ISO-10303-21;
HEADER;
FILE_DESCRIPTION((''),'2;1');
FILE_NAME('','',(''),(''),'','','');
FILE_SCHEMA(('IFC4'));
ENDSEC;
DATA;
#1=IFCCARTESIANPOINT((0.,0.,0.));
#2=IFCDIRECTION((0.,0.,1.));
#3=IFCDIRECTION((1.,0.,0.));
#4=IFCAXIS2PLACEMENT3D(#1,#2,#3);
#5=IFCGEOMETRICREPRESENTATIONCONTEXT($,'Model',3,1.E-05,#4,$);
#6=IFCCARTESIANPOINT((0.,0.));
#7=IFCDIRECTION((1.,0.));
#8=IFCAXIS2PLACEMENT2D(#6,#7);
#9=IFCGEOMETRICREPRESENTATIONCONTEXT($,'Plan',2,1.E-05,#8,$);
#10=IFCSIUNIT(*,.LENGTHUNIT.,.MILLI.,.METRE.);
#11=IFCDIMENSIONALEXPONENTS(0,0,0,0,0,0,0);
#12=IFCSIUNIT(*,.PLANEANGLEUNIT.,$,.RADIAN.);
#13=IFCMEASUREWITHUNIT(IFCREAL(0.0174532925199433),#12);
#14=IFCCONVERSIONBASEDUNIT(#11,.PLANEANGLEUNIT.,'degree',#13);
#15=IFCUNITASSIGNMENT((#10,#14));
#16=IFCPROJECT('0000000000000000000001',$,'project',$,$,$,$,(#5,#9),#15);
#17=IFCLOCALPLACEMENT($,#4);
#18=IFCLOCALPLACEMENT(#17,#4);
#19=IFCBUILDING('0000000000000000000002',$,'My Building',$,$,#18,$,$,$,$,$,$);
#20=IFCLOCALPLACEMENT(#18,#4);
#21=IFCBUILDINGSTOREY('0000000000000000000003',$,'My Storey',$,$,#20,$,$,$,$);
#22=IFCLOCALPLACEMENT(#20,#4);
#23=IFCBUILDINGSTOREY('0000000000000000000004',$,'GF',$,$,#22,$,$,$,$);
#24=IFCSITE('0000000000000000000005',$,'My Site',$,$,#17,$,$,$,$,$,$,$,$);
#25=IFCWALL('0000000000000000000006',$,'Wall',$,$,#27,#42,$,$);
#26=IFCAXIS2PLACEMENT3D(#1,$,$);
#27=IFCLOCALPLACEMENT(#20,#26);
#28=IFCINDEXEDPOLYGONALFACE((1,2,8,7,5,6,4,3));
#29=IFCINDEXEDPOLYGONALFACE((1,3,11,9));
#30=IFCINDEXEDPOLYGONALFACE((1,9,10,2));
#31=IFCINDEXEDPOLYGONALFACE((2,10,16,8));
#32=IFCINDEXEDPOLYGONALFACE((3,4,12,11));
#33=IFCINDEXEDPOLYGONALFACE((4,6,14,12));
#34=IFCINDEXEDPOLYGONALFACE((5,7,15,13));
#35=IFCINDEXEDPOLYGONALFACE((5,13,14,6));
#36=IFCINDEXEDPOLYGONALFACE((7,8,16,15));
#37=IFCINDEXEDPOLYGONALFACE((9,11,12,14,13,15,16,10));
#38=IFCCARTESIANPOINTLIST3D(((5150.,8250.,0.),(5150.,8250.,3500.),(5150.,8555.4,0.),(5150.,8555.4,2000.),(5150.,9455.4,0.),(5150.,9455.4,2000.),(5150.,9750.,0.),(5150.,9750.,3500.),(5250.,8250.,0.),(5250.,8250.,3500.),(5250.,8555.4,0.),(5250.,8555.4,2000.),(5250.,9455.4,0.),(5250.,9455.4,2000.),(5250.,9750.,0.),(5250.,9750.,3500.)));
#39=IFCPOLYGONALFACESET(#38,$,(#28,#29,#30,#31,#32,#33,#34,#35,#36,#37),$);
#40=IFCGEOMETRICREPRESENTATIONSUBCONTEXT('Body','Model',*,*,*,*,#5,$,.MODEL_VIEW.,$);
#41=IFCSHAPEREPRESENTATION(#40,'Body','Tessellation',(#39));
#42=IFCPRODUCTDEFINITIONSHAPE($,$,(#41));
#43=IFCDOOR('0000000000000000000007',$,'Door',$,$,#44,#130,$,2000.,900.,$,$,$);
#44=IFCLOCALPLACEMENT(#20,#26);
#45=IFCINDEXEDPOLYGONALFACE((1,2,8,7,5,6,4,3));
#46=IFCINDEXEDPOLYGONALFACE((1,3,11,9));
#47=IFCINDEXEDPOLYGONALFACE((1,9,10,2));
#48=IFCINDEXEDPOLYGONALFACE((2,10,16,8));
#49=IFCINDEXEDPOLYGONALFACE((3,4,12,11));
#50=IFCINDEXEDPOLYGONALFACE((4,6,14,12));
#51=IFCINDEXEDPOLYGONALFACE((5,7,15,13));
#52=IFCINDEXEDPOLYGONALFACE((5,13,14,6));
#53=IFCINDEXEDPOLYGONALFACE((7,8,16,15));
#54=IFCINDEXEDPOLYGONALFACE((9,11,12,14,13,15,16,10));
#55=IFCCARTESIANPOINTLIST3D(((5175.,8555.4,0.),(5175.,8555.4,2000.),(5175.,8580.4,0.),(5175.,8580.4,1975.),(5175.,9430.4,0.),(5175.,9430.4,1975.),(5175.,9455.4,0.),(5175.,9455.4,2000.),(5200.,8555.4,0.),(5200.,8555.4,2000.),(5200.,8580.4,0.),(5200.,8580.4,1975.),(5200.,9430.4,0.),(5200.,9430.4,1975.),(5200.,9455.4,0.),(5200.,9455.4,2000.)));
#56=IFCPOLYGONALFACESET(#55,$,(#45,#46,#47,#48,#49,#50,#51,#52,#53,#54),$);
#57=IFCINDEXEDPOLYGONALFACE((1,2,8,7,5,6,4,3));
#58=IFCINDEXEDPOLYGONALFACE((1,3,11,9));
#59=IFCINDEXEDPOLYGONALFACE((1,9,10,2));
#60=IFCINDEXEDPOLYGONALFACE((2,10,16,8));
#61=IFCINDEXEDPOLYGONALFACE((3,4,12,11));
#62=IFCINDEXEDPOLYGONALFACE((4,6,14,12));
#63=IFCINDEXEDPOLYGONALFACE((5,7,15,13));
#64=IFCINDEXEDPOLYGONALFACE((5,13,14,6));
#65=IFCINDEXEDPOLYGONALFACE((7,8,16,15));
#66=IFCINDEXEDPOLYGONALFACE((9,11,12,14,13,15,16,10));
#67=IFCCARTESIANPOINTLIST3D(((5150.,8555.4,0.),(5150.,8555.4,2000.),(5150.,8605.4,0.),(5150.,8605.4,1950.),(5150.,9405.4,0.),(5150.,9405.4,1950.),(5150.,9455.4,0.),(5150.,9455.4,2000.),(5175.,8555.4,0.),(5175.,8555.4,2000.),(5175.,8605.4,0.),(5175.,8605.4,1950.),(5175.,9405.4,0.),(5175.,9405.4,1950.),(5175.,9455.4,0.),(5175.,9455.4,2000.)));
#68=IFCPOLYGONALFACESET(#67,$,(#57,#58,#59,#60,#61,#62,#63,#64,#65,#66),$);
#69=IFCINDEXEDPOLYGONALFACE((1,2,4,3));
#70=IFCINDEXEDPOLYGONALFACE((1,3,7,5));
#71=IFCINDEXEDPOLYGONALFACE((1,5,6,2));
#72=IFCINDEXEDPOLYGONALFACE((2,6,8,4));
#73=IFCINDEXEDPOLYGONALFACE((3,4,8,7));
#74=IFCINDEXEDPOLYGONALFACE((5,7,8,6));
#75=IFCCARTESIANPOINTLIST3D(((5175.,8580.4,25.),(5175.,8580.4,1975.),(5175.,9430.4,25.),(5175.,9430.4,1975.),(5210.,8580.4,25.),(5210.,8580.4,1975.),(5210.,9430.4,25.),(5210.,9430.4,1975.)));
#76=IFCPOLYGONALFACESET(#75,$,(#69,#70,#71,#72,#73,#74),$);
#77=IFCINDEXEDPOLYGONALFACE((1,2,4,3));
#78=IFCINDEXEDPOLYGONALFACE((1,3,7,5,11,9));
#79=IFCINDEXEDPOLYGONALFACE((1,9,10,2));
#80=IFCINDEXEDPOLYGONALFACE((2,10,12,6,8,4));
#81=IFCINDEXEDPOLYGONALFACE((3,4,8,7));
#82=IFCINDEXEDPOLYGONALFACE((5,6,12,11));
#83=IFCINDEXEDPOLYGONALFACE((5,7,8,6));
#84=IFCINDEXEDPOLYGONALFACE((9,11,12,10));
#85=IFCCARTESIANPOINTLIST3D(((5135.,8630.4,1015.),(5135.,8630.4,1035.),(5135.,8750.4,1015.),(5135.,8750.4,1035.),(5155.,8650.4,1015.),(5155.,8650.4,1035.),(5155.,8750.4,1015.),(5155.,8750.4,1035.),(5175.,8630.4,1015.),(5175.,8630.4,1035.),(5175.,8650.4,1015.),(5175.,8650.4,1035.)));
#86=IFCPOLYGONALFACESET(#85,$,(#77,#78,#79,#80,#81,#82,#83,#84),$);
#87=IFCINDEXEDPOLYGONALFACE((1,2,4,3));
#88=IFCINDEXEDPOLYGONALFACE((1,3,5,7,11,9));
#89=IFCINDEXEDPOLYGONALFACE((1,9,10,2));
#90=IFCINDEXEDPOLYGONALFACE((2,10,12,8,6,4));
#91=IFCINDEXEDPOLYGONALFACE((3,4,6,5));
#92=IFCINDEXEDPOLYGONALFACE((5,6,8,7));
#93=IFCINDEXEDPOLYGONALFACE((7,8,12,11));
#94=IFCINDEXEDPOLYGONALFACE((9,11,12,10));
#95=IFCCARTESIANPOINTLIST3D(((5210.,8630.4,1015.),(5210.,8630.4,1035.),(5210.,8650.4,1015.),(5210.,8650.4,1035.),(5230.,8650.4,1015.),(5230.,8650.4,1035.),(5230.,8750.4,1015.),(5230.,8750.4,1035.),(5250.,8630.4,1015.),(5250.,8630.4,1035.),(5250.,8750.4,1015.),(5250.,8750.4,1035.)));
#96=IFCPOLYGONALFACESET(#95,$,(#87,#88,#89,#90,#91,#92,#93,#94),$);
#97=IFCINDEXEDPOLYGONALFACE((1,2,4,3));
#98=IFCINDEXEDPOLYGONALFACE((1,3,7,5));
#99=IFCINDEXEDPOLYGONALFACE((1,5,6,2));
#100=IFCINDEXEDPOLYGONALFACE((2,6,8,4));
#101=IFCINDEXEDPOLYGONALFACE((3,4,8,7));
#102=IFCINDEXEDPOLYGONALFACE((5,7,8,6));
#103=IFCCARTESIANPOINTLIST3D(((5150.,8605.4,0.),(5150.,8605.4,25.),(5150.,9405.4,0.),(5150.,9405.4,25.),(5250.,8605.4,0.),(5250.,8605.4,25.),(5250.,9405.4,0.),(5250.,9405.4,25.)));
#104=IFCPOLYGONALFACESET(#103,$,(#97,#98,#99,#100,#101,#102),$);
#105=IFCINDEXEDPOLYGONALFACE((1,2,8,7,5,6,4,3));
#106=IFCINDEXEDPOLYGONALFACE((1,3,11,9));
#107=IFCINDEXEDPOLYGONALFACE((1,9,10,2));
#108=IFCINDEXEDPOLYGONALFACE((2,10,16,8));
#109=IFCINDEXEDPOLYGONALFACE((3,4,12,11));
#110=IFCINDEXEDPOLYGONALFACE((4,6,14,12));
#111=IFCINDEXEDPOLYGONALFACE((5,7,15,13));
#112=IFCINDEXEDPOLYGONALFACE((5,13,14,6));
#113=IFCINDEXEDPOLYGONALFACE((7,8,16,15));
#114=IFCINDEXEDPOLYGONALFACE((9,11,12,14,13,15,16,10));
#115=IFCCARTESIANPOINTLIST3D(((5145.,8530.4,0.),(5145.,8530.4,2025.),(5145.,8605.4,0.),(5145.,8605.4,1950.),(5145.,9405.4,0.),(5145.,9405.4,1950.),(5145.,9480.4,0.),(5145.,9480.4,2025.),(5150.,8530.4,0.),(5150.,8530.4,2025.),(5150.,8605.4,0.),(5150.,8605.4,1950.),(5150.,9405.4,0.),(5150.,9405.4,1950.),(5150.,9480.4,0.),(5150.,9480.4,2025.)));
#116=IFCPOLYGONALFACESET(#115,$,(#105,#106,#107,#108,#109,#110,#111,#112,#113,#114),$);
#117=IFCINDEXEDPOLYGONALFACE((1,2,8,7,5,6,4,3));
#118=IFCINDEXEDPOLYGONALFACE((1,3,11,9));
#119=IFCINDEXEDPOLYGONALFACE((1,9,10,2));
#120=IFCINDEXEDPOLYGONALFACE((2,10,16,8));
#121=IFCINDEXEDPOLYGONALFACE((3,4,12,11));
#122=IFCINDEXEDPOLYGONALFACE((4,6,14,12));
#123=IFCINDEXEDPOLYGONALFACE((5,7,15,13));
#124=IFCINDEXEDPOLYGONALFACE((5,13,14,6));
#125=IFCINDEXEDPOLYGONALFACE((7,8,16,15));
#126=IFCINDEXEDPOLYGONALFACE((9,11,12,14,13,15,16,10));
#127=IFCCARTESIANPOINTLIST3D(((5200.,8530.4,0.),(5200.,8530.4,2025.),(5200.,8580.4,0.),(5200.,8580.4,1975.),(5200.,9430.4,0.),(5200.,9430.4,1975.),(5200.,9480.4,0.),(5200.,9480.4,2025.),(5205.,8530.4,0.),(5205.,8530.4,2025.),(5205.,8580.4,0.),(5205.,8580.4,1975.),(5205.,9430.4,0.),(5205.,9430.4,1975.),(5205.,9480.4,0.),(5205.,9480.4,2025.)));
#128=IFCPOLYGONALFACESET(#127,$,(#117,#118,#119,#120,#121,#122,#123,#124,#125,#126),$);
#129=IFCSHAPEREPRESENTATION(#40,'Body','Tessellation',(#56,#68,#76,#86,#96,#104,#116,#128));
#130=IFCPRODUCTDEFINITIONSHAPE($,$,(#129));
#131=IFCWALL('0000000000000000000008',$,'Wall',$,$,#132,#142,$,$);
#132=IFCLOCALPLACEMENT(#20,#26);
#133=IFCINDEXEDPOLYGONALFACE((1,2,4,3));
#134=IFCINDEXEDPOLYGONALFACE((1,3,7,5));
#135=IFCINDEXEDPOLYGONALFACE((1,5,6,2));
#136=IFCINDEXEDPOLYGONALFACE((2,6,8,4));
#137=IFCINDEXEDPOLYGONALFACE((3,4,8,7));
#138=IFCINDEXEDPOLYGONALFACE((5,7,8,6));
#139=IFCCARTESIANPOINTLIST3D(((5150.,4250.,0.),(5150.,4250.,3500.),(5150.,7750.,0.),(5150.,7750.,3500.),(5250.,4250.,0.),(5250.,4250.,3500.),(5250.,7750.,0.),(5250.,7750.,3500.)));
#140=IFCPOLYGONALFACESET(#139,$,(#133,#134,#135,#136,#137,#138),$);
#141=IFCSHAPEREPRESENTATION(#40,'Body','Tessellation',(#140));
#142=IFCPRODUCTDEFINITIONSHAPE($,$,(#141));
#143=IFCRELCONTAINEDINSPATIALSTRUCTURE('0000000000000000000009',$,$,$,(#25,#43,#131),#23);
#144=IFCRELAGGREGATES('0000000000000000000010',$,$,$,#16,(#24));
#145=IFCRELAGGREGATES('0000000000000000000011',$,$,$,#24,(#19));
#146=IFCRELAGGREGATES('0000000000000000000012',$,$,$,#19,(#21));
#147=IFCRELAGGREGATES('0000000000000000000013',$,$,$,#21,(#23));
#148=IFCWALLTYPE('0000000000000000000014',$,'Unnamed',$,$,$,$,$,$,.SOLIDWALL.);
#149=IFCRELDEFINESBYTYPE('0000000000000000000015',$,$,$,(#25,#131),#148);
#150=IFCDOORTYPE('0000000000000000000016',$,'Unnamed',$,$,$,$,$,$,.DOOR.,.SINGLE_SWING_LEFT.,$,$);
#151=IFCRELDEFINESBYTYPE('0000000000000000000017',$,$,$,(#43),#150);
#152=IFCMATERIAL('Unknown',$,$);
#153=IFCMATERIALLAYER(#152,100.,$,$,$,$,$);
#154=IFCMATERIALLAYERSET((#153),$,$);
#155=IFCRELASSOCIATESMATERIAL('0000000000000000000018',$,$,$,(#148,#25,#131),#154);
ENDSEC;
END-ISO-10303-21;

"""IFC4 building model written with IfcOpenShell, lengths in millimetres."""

from ifc_helpers import new_model, entity, si_unit, converted_unit, frame, origin_with_axes, origin_2d_with_axis, place, context, subcontext, project, spatial, line, indexed_curve, outline, extrude, shape, source, transform, mapped, material, layer, layer_set, layer_usage, type_object, type_shapes, element, fill, save


model = new_model("IFC4")

# Units and contexts
model_context = context("Model", 3, precision=1e-05, world=origin_with_axes())
plan_context = context("Plan", 2, precision=1e-05, world=origin_2d_with_axis())
body_context_1 = subcontext(model_context, "Body", "Model", "MODEL_VIEW")
body_context_2 = subcontext(plan_context, "Body", "Plan", "PLAN_VIEW")
ifc_project = project(units=[si_unit("LENGTHUNIT", "METRE", prefix="MILLI"), converted_unit("PLANEANGLEUNIT", "degree", entity("IfcReal", 0.0174532925199433), si_unit("PLANEANGLEUNIT", "RADIAN"), dimensions=[0, 0, 0, 0, 0, 0, 0])], contexts=[model_context, plan_context])

# Site, building, storeys
site_placement = place(None, origin_with_axes())
site = spatial("IfcSite", under=ifc_project, at=site_placement, Name="My Site")
building_placement = place(site_placement, origin_with_axes())
building = spatial("IfcBuilding", under=site, at=building_placement, Name="My Building")
storey_1_placement = place(building_placement, origin_with_axes())
storey_1 = spatial("IfcBuildingStorey", under=building, at=storey_1_placement, Name="My Storey")
storey_2_placement = place(storey_1_placement, origin_with_axes())
storey_2 = spatial("IfcBuildingStorey", under=storey_1, at=storey_2_placement, Name="GF")

# Shared definitions
ifc_material = material(Name="Unknown")
ifc_layer_1 = layer(ifc_material, 100.0)
ifc_layer_set_1 = layer_set([ifc_layer_1])
wall_type_1 = type_object("IfcWallType", Name="Unnamed", PredefinedType="SOLIDWALL", material=ifc_layer_set_1)

# Shared definitions
shared_shape_1 = source(origin_with_axes(), body_context_1, "Body", "SweptSolid", [
    extrude(outline(indexed_curve([(0.0, 0.0), (900.0, 0.0), (900.0, 2000.0), (0.0, 2000.0)], segments=[line(1, 2, 3, 4, 1)])), frame((0.0, -600.0, 0.0), z_axis=(0.0, -1.0, 0.0), x_axis=(1.0, 0.0, 0.0)), (0.0, 0.0, -1.0), 1200.0),
])
door_type = type_object("IfcDoorType", Name="Unnamed", OperationType="SINGLE_SWING_LEFT", PredefinedType="DOOR")
shared_shape_2 = source(origin_with_axes(), body_context_1, "Body", "SweptSolid", [
    extrude(outline(indexed_curve([(0.0, 0.0), (0.0, 2000.0), (900.0, 2000.0), (900.0, 0.0), (875.0, 0.0), (875.0, 1975.0), (25.0, 1975.0), (25.0, 0.0)], segments=[line(1, 2, 3, 4, 5, 6, 7, 8, 1)])), frame((0.0, 25.0, 0.0), z_axis=(0.0, -1.0, 0.0), x_axis=(1.0, 0.0, 0.0)), (0.0, 0.0, -1.0), 25.0),
    extrude(outline(indexed_curve([(0.0, 0.0), (0.0, 2000.0), (900.0, 2000.0), (900.0, 0.0), (850.0, 0.0), (850.0, 1950.0), (50.0, 1950.0), (50.0, 0.0)], segments=[line(1, 2, 3, 4, 5, 6, 7, 8, 1)])), frame((0.0, 0.0, 0.0), z_axis=(0.0, -1.0, 0.0), x_axis=(1.0, 0.0, 0.0)), (0.0, 0.0, -1.0), 25.0),
    extrude(outline(indexed_curve([(0.0, 0.0), (850.0, 0.0), (850.0, 35.0), (0.0, 35.0)], segments=[line(1, 2, 3, 4, 1)])), frame((25.0, 25.0, 25.0), z_axis=(0.0, 0.0, 1.0), x_axis=(1.0, 0.0, 0.0)), (0.0, 0.0, 1.0), 1950.0),
    extrude(outline(indexed_curve([(0.0, 0.0), (0.0, -40.0), (-120.0, -40.0), (-120.0, -20.0), (-20.0, -20.0), (-20.0, 0.0)], segments=[line(1, 2, 3, 4, 5, 6, 1)])), frame((825.0, 25.0, 1015.0), z_axis=(0.0, 0.0, 1.0), x_axis=(1.0, 0.0, 0.0)), (0.0, 0.0, 1.0), 20.0),
    extrude(outline(indexed_curve([(0.0, 0.0), (0.0, 40.0), (-120.0, 40.0), (-120.0, 20.0), (-20.0, 20.0), (-20.0, 0.0)], segments=[line(1, 2, 3, 4, 5, 6, 1)])), frame((825.0, 60.0, 1015.0), z_axis=(0.0, 0.0, 1.0), x_axis=(1.0, 0.0, 0.0)), (0.0, 0.0, 1.0), 20.0),
    extrude(outline(indexed_curve([(0.0, 0.0), (800.0, 0.0), (800.0, 100.0), (0.0, 100.0)], segments=[line(1, 2, 3, 4, 1)])), frame((50.0, 0.0, 0.0), z_axis=(0.0, 0.0, 1.0), x_axis=(1.0, 0.0, 0.0)), (0.0, 0.0, 1.0), 25.0),
    extrude(outline(indexed_curve([(0.0, 0.0), (0.0, 2025.0), (950.0, 2025.0), (950.0, 0.0), (875.0, 0.0), (875.0, 1950.0), (75.0, 1950.0), (75.0, 0.0)], segments=[line(1, 2, 3, 4, 5, 6, 7, 8, 1)])), frame((-25.0, -5.0, 0.0), z_axis=(0.0, -1.0, 0.0), x_axis=(1.0, 0.0, 0.0)), (0.0, 0.0, -1.0), 5.0),
    extrude(outline(indexed_curve([(0.0, 0.0), (0.0, 2025.0), (950.0, 2025.0), (950.0, 0.0), (900.0, 0.0), (900.0, 1975.0), (50.0, 1975.0), (50.0, 0.0)], segments=[line(1, 2, 3, 4, 5, 6, 7, 8, 1)])), frame((-25.0, 50.0, 0.0), z_axis=(0.0, -1.0, 0.0), x_axis=(1.0, 0.0, 0.0)), (0.0, 0.0, -1.0), 5.0),
])
shared_shape_3 = source(origin_with_axes(), body_context_2, "Body", "Curve2D", [
    entity("IfcIndexedPolyCurve", entity("IfcCartesianPointList2D", [[0.0, 0.0], [0.0, 50.0], [25.0, 50.0], [25.0, 25.0], [50.0, 25.0], [50.0, 0.0]]), [entity("IfcLineIndex", [1, 2, 3, 4, 5, 6, 1])]),
    entity("IfcIndexedPolyCurve", entity("IfcCartesianPointList2D", [[900.0, 0.0], [900.0, 50.0], [875.0, 50.0], [875.0, 25.0], [850.0, 25.0], [850.0, 0.0]]), [entity("IfcLineIndex", [1, 2, 3, 4, 5, 6, 1])]),
    entity("IfcTrimmedCurve", entity("IfcEllipse", entity("IfcAxis2Placement2D", entity("IfcCartesianPoint", [60.0, 50.0]), entity("IfcDirection", [1.0, 0.0])), 815.0, 850.0), [entity("IfcCartesianPoint", [875.0, 50.0])], [entity("IfcCartesianPoint", [60.0, 900.0])], True, "CARTESIAN"),
    entity("IfcIndexedPolyCurve", entity("IfcCartesianPointList2D", [[25.0, 50.0], [60.0, 50.0], [60.0, 900.0], [25.0, 900.0]]), [entity("IfcLineIndex", [1, 2, 3, 4, 1])]),
])
type_shapes(door_type, [shared_shape_2, shared_shape_3])

# Wall, opening, door
ifc_layer_usage_1 = layer_usage(ifc_layer_set_1, "AXIS2", "POSITIVE", 0.0)
wall_1_placement = place(storey_2_placement, frame((5150.0, 9750.0, 0.0), z_axis=(0.0, 0.0, 1.0), x_axis=(0.0, -1.0, 0.0)))
wall_1 = element("IfcWall", 1, at=wall_1_placement, inside=storey_2, type_object=wall_type_1, material=ifc_layer_usage_1, Name="Wall", context=body_context_1, shape_type="SweptSolid", body=[
    extrude(outline(indexed_curve([(0.0, 0.0), (0.0, 100.0), (1500.0, 100.0), (1500.0, 0.0)], segments=[line(1, 2, 3, 4, 1)])), origin_with_axes(), (0.0, 0.0, 1.0), 3500.0),
])
opening_1_placement = place(wall_1_placement, frame((294.6, 0.0, 0.0), z_axis=(0.0, 0.0, 1.0), x_axis=(1.0, 0.0, 0.0)))
opening_1 = element("IfcOpeningElement", 2, at=opening_1_placement, cuts=wall_1, PredefinedType="OPENING", context=body_context_1, shape_type="MappedRepresentation", body=[
    mapped(shared_shape_1, transform((0.0, 0.0, 0.0), x_axis=(1.0, 0.0, 0.0), y_axis=(0.0, 1.0, 0.0), z_axis=(0.0, 0.0, 1.0), scale=1.0)),
])
door_1_placement = place(opening_1_placement, origin_with_axes())
door_1 = element("IfcDoor", 3, at=door_1_placement, inside=storey_2, type_object=door_type, Name="Door", OverallHeight=2000.0, OverallWidth=900.0, shapes=[
    shape(body_context_1, "Body", "MappedRepresentation", [mapped(shared_shape_2, transform((0.0, 0.0, 0.0), x_axis=(1.0, 0.0, 0.0), y_axis=(0.0, 1.0, 0.0), z_axis=(0.0, 0.0, 1.0), scale=1.0))]),
    shape(body_context_2, "Body", "MappedRepresentation", [mapped(shared_shape_3, transform((0.0, 0.0, 0.0), x_axis=(1.0, 0.0, 0.0), y_axis=(0.0, 1.0, 0.0), z_axis=(0.0, 0.0, 1.0), scale=1.0))]),
])
fill(opening_1, door_1)

# Wall
ifc_layer_usage_2 = layer_usage(ifc_layer_set_1, "AXIS2", "POSITIVE", 0.0)
wall_2_placement = place(storey_2_placement, frame((5150.0, 7750.0, 0.0), z_axis=(0.0, 0.0, 1.0), x_axis=(0.0, -1.0, 0.0)))
element("IfcWall", 4, at=wall_2_placement, inside=storey_2, type_object=wall_type_1, material=ifc_layer_usage_2, Name="Wall", context=body_context_1, shape_type="SweptSolid", body=[
    extrude(outline(indexed_curve([(0.0, 0.0), (0.0, 100.0), (3500.0, 100.0), (3500.0, 0.0)], segments=[line(1, 2, 3, 4, 1)])), origin_with_axes(), (0.0, 0.0, 1.0), 3500.0),
])

save(model, "model.ifc")
